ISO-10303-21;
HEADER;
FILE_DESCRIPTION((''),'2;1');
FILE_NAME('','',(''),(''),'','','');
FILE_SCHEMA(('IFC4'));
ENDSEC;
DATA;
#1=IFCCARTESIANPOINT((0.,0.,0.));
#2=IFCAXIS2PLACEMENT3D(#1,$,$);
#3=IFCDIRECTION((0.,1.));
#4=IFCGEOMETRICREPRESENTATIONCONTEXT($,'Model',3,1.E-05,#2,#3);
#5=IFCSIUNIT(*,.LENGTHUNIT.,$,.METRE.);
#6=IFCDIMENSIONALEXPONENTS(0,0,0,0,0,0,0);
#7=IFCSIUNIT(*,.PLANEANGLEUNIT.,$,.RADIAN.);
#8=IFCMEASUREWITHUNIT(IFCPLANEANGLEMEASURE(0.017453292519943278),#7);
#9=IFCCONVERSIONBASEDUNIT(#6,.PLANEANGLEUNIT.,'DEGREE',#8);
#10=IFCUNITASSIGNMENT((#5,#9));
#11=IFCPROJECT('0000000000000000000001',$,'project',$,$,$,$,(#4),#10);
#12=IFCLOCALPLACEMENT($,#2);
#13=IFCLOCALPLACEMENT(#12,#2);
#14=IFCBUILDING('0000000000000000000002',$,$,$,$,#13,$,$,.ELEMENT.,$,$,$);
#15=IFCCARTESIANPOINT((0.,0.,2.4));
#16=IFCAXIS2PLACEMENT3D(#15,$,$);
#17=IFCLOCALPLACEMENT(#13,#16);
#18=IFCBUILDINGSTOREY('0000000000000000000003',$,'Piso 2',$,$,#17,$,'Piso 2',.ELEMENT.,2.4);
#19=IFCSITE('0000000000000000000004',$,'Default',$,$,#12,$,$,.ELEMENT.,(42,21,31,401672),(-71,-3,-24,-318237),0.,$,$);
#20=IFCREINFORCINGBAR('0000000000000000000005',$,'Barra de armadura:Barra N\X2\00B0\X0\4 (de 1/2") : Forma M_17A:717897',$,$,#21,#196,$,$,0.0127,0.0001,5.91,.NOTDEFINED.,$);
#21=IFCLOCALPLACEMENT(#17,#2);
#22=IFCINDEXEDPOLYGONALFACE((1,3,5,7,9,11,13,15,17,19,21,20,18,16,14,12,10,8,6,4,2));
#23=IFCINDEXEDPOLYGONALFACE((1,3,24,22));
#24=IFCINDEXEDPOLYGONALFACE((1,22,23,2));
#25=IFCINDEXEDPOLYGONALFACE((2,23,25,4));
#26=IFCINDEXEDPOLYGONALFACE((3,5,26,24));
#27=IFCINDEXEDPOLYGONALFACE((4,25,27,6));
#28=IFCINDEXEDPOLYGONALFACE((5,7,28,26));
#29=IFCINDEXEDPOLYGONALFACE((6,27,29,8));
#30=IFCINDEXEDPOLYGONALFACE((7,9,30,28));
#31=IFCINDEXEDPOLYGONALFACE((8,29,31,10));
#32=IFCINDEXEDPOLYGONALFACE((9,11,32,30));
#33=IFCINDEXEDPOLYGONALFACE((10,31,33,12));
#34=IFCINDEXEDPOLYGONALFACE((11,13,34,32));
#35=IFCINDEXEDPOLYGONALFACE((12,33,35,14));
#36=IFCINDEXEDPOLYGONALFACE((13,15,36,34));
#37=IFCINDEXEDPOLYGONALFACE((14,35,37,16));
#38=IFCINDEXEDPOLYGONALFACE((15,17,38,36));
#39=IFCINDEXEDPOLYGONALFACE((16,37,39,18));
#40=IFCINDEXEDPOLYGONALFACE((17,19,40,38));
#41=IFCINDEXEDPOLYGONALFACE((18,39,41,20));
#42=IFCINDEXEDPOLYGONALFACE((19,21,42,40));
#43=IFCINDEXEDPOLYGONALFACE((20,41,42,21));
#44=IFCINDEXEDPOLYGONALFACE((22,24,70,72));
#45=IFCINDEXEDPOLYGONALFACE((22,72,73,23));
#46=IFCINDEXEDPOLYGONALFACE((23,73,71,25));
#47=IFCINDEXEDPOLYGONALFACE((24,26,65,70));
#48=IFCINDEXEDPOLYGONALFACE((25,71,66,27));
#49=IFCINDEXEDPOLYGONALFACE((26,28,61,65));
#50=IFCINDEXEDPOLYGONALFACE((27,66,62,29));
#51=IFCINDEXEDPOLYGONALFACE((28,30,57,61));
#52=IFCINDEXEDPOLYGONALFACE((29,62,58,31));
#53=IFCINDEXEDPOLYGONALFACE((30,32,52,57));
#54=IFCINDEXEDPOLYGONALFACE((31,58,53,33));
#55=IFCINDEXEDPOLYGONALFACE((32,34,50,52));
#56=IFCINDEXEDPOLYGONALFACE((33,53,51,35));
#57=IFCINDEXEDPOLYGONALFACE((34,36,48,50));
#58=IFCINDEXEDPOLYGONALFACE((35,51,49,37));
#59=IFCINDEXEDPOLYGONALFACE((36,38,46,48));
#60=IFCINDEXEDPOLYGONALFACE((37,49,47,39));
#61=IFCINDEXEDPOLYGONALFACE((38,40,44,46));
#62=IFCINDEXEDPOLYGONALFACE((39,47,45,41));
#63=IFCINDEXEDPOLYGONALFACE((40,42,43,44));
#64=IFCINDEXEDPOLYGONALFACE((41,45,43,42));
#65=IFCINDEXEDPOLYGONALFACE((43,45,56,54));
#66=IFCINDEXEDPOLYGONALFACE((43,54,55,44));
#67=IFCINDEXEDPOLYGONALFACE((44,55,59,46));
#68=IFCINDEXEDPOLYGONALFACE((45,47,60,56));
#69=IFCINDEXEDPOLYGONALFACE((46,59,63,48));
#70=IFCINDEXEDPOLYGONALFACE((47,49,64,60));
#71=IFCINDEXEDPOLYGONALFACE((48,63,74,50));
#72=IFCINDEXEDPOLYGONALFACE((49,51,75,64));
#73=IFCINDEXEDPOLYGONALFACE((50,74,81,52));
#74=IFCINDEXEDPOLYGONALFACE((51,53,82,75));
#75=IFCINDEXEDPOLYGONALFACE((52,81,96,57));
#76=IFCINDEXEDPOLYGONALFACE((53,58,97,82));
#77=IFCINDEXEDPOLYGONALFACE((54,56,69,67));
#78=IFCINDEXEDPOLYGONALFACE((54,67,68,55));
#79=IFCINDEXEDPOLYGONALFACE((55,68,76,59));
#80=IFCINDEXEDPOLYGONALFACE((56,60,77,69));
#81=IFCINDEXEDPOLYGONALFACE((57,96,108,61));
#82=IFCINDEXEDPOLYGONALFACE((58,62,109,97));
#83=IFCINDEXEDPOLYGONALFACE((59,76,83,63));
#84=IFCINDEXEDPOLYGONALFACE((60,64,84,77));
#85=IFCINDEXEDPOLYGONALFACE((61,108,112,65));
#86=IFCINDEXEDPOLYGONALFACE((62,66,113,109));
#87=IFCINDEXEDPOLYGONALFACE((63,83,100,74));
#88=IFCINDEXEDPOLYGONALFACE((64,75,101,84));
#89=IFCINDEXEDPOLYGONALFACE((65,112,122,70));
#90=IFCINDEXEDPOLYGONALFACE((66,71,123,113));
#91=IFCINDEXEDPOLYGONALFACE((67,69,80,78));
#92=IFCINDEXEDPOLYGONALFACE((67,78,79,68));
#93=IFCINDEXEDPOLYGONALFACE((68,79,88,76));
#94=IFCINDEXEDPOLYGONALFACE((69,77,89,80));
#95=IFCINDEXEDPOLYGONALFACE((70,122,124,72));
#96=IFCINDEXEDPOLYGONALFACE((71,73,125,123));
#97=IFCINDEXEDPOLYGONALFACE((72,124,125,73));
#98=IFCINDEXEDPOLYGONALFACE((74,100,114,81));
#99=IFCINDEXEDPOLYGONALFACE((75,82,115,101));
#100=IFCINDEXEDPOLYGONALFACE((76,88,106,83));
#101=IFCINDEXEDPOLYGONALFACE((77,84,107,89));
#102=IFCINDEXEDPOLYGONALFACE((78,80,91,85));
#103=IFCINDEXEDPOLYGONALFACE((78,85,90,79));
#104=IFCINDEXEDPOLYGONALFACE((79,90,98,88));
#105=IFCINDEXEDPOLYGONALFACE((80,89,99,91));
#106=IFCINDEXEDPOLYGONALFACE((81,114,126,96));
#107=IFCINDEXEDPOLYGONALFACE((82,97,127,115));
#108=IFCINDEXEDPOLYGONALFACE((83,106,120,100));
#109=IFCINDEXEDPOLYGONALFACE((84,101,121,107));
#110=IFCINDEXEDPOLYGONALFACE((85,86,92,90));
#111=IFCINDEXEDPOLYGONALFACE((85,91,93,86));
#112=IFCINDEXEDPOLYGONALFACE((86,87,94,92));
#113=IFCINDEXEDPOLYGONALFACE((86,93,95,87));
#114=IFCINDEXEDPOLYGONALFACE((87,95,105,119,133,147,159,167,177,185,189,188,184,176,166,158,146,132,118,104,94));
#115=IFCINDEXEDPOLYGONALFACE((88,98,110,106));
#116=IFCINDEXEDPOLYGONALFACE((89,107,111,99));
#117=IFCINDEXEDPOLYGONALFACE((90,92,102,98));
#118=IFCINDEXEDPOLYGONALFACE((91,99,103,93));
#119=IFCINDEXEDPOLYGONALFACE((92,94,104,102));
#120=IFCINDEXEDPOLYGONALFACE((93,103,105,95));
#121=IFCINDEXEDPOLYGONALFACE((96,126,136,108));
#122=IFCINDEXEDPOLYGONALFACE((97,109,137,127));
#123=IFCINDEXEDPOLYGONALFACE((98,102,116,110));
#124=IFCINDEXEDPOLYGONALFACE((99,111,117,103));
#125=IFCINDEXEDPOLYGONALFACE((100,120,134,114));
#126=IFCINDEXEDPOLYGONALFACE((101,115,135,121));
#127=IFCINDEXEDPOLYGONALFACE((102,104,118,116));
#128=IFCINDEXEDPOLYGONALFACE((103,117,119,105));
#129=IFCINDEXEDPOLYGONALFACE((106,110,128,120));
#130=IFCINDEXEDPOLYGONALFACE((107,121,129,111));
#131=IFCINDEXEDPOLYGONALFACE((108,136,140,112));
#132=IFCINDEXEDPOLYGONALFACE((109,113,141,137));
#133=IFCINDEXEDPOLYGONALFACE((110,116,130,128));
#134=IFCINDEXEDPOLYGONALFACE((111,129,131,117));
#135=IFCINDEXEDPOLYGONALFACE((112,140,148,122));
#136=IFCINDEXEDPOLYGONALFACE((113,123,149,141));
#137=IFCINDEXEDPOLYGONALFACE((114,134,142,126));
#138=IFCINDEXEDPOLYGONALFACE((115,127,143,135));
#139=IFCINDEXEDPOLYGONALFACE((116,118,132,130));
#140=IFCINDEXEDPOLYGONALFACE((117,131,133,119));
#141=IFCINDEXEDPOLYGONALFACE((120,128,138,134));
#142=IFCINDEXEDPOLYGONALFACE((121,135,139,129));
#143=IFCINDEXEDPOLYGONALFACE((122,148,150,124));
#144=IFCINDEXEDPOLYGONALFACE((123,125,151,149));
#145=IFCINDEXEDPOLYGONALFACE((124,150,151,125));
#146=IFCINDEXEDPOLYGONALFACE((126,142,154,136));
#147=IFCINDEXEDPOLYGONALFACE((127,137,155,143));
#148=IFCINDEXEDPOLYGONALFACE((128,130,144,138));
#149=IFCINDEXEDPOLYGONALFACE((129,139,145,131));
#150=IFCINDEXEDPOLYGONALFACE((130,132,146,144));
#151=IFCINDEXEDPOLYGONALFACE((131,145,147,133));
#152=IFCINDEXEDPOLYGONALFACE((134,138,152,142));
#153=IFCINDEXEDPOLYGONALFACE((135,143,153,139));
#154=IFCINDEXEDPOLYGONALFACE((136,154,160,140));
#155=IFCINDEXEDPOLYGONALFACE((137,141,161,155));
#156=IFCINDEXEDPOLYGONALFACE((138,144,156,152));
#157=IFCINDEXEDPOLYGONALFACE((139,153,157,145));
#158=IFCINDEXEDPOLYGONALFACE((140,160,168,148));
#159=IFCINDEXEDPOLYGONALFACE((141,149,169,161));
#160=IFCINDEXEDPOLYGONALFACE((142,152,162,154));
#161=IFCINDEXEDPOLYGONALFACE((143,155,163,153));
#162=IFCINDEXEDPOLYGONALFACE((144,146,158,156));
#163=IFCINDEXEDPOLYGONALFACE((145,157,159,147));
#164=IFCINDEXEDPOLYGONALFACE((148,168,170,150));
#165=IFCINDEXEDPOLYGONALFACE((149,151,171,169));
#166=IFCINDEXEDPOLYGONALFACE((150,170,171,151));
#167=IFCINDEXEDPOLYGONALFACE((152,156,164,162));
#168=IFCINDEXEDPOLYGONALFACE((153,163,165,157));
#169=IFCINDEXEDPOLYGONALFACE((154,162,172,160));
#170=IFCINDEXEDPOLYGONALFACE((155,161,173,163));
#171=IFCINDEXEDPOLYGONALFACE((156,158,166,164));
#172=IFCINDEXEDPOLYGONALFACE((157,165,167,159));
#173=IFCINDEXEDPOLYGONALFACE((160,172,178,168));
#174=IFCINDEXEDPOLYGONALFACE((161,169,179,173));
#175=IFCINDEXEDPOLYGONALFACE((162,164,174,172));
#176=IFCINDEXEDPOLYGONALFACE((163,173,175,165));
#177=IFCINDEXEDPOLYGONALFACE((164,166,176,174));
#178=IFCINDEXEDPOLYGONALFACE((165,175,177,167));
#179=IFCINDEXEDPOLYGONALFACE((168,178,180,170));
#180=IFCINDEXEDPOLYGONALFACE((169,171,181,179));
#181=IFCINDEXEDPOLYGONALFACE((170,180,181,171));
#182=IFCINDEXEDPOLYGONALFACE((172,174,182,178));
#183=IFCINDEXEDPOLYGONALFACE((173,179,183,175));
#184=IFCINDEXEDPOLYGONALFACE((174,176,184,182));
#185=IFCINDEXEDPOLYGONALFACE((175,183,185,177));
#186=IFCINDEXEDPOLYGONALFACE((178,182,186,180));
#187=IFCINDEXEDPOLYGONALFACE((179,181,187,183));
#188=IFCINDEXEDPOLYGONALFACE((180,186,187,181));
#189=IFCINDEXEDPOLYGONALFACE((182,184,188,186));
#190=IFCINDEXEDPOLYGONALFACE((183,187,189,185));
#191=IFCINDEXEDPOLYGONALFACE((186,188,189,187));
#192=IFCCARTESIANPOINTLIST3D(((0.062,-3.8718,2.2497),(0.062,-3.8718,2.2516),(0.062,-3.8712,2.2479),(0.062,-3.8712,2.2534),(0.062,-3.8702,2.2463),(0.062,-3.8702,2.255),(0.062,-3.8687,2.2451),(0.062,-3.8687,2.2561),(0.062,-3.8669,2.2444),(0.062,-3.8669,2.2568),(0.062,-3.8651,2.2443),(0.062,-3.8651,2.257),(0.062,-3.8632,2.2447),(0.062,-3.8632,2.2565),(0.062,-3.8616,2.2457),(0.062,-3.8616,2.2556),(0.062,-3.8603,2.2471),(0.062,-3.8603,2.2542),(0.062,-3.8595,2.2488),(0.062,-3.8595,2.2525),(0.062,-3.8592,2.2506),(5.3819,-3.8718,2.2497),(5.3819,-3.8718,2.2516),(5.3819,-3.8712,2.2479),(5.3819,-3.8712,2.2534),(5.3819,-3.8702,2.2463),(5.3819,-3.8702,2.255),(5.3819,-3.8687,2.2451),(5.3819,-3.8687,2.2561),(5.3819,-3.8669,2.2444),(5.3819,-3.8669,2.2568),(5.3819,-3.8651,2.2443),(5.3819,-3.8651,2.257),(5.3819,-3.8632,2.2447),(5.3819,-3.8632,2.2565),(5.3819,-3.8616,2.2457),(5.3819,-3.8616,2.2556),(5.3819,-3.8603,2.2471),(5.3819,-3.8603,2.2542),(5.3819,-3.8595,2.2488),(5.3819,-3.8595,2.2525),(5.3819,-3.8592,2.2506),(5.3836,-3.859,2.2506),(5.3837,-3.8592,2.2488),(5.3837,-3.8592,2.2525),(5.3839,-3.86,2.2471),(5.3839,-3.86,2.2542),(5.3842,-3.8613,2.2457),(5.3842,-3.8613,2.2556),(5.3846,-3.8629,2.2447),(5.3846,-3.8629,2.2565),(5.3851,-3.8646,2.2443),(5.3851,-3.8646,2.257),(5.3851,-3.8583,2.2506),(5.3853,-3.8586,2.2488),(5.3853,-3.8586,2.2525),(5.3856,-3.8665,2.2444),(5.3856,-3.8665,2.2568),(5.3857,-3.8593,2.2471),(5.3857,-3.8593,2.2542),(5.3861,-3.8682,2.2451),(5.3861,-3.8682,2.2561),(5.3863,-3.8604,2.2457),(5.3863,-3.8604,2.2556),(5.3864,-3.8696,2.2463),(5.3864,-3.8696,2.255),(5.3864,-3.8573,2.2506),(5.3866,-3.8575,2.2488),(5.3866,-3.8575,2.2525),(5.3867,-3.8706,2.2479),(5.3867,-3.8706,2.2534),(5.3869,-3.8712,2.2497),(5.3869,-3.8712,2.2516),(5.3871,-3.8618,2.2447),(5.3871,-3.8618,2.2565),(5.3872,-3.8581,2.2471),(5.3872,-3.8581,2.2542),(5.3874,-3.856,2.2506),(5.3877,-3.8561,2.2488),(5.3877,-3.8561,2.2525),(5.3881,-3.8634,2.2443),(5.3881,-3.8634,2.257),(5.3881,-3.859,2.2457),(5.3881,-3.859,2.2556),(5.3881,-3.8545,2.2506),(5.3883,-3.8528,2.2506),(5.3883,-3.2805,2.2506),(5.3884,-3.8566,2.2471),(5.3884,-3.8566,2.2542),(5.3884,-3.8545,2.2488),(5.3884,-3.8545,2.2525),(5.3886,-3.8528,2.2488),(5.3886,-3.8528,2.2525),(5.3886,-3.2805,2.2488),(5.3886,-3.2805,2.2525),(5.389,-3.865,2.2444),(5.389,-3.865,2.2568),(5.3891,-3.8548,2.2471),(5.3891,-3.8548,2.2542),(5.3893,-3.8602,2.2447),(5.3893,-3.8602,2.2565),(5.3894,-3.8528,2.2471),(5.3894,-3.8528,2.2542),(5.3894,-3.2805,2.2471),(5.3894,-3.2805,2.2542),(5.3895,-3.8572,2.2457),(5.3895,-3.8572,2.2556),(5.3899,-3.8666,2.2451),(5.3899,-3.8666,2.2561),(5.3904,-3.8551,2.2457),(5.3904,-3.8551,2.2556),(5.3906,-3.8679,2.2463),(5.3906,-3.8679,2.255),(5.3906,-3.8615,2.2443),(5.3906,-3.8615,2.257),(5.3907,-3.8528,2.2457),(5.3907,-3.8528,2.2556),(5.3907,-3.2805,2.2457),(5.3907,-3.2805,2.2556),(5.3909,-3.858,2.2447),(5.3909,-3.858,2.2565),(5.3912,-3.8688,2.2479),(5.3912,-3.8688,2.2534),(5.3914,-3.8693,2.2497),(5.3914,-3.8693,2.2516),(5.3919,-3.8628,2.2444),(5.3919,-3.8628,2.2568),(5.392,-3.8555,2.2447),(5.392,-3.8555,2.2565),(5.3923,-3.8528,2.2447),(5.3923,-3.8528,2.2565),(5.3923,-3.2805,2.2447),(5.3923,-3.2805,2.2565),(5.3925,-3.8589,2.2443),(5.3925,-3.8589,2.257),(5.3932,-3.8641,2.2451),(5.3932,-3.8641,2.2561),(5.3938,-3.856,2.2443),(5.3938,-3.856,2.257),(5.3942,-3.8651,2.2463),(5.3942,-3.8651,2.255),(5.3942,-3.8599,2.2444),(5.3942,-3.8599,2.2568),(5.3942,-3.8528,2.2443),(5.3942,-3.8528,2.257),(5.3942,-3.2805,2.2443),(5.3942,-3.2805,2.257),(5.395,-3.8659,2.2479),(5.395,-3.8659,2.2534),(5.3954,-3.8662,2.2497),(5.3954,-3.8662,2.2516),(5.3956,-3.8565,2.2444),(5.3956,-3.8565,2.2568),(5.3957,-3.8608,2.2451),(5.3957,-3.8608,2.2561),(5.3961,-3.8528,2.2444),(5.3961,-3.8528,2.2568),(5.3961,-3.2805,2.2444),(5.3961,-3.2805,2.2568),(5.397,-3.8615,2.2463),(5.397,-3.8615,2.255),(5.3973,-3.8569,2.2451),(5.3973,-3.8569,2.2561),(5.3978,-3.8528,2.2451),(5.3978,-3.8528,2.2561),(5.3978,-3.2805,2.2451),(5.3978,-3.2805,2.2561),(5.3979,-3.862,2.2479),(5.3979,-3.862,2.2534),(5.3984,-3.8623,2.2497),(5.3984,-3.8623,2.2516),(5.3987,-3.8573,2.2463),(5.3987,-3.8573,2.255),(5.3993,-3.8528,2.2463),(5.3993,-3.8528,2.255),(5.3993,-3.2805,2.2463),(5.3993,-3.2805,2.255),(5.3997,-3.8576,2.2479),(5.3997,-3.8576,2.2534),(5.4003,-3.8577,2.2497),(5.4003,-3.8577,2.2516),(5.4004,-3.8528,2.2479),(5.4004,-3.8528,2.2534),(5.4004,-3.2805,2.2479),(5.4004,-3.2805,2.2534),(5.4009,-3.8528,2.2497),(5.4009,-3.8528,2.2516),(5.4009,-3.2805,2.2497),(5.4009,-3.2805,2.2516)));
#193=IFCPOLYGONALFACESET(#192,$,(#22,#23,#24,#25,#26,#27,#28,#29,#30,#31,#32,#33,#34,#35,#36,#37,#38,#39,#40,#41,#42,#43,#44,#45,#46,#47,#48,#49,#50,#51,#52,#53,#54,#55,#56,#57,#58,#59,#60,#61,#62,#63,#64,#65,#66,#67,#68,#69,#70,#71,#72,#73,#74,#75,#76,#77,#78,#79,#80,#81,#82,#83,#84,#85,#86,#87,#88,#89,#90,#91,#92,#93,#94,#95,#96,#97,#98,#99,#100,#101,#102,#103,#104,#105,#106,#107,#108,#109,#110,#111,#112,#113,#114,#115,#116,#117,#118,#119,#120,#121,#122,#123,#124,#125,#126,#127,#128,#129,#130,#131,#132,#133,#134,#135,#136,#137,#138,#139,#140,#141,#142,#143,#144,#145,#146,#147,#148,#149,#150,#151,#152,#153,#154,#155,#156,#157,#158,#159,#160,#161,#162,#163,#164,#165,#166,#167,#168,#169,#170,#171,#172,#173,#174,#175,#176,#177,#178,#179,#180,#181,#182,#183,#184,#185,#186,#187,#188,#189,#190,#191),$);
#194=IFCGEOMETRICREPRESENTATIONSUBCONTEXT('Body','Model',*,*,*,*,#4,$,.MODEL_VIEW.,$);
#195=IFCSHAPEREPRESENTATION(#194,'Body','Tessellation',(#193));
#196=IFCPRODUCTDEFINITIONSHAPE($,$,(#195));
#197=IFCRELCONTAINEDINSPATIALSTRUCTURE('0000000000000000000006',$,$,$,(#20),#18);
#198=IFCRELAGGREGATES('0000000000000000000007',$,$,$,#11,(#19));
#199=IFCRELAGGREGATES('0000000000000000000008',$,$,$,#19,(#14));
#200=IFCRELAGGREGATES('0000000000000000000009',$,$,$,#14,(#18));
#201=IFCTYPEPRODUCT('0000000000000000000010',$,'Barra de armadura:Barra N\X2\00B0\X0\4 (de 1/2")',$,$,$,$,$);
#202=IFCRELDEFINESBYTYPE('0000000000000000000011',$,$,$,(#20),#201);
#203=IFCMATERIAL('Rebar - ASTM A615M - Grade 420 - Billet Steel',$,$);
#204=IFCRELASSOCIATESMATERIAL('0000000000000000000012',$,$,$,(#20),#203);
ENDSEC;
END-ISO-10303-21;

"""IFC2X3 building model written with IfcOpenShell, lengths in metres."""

from ifc_helpers import new_model, entity, si_unit, converted_unit, direction, frame, origin, place, context, subcontext, project, spatial, material, type_object, element, save


model = new_model("IFC2X3")

# Units and contexts
model_context = context("Model", 3, precision=1e-05, world=origin(), true_north=direction((0.0, 1.0)))
body_context = subcontext(model_context, "Body", "Model", "MODEL_VIEW")
ifc_project = project(units=[si_unit("LENGTHUNIT", "METRE"), converted_unit("PLANEANGLEUNIT", "DEGREE", entity("IfcPlaneAngleMeasure", 0.017453292519943278), si_unit("PLANEANGLEUNIT", "RADIAN"), dimensions=[0, 0, 0, 0, 0, 0, 0])], contexts=[model_context])

# Site, building, storey
site_placement = place(None, origin())
site = spatial("IfcSite", under=ifc_project, at=site_placement, Name="Default", CompositionType="ELEMENT", RefLatitude=(42, 21, 31, 401672), RefLongitude=(-71, -3, -24, -318237), RefElevation=0.0)
building_placement = place(site_placement, origin())
building = spatial("IfcBuilding", under=site, at=building_placement, CompositionType="ELEMENT")
storey_placement = place(building_placement, frame((0.0, 0.0, 2.4)))
storey = spatial("IfcBuildingStorey", under=building, at=storey_placement, Name="Piso 2", LongName="Piso 2", CompositionType="ELEMENT", Elevation=2.4)

# Reinforcing bar
ifc_material_1 = material(Name="Rebar - ASTM A615M - Grade 420 - Billet Steel")
type_product_1 = type_object("IfcTypeProduct", Name="Barra de armadura:Barra N°4 (de 1/2\")")
reinforcing_bar_1_placement = place(storey_placement, origin())
element("IfcReinforcingBar", 1, at=reinforcing_bar_1_placement, inside=storey, type_object=type_product_1, material=ifc_material_1, Name="Barra de armadura:Barra N°4 (de 1/2\") : Forma M_17A:717897", BarLength=5.91, BarRole="NOTDEFINED", CrossSectionArea=0.0001, NominalDiameter=0.0127, context=body_context, shape_type="AdvancedSweptSolid", body=[
    entity("IfcSweptDiskSolid", entity("IfcCompositeCurve", [entity("IfcCompositeCurveSegment", "CONTINUOUS", True, entity("IfcPolyline", [entity("IfcCartesianPoint", [0.062, -3.8655, 2.2506]), entity("IfcCartesianPoint", [5.3819, -3.8655, 2.2506])])), entity("IfcCompositeCurveSegment", "CONTINUOUS", True, entity("IfcTrimmedCurve", entity("IfcCircle", entity("IfcAxis2Placement3D", entity("IfcCartesianPoint", [5.3819, -3.8528, 2.2506])), 0.0127), [entity("IfcParameterValue", 270.0)], [entity("IfcParameterValue", 360.0)], True, "PARAMETER")), entity("IfcCompositeCurveSegment", "CONTINUOUS", True, entity("IfcPolyline", [entity("IfcCartesianPoint", [5.3946, -3.8528, 2.2506]), entity("IfcCartesianPoint", [5.3946, -3.2805, 2.2506])]))], False), 0.0063, None, 0.0, 92.0),
])

save(model, "model.ifc")
